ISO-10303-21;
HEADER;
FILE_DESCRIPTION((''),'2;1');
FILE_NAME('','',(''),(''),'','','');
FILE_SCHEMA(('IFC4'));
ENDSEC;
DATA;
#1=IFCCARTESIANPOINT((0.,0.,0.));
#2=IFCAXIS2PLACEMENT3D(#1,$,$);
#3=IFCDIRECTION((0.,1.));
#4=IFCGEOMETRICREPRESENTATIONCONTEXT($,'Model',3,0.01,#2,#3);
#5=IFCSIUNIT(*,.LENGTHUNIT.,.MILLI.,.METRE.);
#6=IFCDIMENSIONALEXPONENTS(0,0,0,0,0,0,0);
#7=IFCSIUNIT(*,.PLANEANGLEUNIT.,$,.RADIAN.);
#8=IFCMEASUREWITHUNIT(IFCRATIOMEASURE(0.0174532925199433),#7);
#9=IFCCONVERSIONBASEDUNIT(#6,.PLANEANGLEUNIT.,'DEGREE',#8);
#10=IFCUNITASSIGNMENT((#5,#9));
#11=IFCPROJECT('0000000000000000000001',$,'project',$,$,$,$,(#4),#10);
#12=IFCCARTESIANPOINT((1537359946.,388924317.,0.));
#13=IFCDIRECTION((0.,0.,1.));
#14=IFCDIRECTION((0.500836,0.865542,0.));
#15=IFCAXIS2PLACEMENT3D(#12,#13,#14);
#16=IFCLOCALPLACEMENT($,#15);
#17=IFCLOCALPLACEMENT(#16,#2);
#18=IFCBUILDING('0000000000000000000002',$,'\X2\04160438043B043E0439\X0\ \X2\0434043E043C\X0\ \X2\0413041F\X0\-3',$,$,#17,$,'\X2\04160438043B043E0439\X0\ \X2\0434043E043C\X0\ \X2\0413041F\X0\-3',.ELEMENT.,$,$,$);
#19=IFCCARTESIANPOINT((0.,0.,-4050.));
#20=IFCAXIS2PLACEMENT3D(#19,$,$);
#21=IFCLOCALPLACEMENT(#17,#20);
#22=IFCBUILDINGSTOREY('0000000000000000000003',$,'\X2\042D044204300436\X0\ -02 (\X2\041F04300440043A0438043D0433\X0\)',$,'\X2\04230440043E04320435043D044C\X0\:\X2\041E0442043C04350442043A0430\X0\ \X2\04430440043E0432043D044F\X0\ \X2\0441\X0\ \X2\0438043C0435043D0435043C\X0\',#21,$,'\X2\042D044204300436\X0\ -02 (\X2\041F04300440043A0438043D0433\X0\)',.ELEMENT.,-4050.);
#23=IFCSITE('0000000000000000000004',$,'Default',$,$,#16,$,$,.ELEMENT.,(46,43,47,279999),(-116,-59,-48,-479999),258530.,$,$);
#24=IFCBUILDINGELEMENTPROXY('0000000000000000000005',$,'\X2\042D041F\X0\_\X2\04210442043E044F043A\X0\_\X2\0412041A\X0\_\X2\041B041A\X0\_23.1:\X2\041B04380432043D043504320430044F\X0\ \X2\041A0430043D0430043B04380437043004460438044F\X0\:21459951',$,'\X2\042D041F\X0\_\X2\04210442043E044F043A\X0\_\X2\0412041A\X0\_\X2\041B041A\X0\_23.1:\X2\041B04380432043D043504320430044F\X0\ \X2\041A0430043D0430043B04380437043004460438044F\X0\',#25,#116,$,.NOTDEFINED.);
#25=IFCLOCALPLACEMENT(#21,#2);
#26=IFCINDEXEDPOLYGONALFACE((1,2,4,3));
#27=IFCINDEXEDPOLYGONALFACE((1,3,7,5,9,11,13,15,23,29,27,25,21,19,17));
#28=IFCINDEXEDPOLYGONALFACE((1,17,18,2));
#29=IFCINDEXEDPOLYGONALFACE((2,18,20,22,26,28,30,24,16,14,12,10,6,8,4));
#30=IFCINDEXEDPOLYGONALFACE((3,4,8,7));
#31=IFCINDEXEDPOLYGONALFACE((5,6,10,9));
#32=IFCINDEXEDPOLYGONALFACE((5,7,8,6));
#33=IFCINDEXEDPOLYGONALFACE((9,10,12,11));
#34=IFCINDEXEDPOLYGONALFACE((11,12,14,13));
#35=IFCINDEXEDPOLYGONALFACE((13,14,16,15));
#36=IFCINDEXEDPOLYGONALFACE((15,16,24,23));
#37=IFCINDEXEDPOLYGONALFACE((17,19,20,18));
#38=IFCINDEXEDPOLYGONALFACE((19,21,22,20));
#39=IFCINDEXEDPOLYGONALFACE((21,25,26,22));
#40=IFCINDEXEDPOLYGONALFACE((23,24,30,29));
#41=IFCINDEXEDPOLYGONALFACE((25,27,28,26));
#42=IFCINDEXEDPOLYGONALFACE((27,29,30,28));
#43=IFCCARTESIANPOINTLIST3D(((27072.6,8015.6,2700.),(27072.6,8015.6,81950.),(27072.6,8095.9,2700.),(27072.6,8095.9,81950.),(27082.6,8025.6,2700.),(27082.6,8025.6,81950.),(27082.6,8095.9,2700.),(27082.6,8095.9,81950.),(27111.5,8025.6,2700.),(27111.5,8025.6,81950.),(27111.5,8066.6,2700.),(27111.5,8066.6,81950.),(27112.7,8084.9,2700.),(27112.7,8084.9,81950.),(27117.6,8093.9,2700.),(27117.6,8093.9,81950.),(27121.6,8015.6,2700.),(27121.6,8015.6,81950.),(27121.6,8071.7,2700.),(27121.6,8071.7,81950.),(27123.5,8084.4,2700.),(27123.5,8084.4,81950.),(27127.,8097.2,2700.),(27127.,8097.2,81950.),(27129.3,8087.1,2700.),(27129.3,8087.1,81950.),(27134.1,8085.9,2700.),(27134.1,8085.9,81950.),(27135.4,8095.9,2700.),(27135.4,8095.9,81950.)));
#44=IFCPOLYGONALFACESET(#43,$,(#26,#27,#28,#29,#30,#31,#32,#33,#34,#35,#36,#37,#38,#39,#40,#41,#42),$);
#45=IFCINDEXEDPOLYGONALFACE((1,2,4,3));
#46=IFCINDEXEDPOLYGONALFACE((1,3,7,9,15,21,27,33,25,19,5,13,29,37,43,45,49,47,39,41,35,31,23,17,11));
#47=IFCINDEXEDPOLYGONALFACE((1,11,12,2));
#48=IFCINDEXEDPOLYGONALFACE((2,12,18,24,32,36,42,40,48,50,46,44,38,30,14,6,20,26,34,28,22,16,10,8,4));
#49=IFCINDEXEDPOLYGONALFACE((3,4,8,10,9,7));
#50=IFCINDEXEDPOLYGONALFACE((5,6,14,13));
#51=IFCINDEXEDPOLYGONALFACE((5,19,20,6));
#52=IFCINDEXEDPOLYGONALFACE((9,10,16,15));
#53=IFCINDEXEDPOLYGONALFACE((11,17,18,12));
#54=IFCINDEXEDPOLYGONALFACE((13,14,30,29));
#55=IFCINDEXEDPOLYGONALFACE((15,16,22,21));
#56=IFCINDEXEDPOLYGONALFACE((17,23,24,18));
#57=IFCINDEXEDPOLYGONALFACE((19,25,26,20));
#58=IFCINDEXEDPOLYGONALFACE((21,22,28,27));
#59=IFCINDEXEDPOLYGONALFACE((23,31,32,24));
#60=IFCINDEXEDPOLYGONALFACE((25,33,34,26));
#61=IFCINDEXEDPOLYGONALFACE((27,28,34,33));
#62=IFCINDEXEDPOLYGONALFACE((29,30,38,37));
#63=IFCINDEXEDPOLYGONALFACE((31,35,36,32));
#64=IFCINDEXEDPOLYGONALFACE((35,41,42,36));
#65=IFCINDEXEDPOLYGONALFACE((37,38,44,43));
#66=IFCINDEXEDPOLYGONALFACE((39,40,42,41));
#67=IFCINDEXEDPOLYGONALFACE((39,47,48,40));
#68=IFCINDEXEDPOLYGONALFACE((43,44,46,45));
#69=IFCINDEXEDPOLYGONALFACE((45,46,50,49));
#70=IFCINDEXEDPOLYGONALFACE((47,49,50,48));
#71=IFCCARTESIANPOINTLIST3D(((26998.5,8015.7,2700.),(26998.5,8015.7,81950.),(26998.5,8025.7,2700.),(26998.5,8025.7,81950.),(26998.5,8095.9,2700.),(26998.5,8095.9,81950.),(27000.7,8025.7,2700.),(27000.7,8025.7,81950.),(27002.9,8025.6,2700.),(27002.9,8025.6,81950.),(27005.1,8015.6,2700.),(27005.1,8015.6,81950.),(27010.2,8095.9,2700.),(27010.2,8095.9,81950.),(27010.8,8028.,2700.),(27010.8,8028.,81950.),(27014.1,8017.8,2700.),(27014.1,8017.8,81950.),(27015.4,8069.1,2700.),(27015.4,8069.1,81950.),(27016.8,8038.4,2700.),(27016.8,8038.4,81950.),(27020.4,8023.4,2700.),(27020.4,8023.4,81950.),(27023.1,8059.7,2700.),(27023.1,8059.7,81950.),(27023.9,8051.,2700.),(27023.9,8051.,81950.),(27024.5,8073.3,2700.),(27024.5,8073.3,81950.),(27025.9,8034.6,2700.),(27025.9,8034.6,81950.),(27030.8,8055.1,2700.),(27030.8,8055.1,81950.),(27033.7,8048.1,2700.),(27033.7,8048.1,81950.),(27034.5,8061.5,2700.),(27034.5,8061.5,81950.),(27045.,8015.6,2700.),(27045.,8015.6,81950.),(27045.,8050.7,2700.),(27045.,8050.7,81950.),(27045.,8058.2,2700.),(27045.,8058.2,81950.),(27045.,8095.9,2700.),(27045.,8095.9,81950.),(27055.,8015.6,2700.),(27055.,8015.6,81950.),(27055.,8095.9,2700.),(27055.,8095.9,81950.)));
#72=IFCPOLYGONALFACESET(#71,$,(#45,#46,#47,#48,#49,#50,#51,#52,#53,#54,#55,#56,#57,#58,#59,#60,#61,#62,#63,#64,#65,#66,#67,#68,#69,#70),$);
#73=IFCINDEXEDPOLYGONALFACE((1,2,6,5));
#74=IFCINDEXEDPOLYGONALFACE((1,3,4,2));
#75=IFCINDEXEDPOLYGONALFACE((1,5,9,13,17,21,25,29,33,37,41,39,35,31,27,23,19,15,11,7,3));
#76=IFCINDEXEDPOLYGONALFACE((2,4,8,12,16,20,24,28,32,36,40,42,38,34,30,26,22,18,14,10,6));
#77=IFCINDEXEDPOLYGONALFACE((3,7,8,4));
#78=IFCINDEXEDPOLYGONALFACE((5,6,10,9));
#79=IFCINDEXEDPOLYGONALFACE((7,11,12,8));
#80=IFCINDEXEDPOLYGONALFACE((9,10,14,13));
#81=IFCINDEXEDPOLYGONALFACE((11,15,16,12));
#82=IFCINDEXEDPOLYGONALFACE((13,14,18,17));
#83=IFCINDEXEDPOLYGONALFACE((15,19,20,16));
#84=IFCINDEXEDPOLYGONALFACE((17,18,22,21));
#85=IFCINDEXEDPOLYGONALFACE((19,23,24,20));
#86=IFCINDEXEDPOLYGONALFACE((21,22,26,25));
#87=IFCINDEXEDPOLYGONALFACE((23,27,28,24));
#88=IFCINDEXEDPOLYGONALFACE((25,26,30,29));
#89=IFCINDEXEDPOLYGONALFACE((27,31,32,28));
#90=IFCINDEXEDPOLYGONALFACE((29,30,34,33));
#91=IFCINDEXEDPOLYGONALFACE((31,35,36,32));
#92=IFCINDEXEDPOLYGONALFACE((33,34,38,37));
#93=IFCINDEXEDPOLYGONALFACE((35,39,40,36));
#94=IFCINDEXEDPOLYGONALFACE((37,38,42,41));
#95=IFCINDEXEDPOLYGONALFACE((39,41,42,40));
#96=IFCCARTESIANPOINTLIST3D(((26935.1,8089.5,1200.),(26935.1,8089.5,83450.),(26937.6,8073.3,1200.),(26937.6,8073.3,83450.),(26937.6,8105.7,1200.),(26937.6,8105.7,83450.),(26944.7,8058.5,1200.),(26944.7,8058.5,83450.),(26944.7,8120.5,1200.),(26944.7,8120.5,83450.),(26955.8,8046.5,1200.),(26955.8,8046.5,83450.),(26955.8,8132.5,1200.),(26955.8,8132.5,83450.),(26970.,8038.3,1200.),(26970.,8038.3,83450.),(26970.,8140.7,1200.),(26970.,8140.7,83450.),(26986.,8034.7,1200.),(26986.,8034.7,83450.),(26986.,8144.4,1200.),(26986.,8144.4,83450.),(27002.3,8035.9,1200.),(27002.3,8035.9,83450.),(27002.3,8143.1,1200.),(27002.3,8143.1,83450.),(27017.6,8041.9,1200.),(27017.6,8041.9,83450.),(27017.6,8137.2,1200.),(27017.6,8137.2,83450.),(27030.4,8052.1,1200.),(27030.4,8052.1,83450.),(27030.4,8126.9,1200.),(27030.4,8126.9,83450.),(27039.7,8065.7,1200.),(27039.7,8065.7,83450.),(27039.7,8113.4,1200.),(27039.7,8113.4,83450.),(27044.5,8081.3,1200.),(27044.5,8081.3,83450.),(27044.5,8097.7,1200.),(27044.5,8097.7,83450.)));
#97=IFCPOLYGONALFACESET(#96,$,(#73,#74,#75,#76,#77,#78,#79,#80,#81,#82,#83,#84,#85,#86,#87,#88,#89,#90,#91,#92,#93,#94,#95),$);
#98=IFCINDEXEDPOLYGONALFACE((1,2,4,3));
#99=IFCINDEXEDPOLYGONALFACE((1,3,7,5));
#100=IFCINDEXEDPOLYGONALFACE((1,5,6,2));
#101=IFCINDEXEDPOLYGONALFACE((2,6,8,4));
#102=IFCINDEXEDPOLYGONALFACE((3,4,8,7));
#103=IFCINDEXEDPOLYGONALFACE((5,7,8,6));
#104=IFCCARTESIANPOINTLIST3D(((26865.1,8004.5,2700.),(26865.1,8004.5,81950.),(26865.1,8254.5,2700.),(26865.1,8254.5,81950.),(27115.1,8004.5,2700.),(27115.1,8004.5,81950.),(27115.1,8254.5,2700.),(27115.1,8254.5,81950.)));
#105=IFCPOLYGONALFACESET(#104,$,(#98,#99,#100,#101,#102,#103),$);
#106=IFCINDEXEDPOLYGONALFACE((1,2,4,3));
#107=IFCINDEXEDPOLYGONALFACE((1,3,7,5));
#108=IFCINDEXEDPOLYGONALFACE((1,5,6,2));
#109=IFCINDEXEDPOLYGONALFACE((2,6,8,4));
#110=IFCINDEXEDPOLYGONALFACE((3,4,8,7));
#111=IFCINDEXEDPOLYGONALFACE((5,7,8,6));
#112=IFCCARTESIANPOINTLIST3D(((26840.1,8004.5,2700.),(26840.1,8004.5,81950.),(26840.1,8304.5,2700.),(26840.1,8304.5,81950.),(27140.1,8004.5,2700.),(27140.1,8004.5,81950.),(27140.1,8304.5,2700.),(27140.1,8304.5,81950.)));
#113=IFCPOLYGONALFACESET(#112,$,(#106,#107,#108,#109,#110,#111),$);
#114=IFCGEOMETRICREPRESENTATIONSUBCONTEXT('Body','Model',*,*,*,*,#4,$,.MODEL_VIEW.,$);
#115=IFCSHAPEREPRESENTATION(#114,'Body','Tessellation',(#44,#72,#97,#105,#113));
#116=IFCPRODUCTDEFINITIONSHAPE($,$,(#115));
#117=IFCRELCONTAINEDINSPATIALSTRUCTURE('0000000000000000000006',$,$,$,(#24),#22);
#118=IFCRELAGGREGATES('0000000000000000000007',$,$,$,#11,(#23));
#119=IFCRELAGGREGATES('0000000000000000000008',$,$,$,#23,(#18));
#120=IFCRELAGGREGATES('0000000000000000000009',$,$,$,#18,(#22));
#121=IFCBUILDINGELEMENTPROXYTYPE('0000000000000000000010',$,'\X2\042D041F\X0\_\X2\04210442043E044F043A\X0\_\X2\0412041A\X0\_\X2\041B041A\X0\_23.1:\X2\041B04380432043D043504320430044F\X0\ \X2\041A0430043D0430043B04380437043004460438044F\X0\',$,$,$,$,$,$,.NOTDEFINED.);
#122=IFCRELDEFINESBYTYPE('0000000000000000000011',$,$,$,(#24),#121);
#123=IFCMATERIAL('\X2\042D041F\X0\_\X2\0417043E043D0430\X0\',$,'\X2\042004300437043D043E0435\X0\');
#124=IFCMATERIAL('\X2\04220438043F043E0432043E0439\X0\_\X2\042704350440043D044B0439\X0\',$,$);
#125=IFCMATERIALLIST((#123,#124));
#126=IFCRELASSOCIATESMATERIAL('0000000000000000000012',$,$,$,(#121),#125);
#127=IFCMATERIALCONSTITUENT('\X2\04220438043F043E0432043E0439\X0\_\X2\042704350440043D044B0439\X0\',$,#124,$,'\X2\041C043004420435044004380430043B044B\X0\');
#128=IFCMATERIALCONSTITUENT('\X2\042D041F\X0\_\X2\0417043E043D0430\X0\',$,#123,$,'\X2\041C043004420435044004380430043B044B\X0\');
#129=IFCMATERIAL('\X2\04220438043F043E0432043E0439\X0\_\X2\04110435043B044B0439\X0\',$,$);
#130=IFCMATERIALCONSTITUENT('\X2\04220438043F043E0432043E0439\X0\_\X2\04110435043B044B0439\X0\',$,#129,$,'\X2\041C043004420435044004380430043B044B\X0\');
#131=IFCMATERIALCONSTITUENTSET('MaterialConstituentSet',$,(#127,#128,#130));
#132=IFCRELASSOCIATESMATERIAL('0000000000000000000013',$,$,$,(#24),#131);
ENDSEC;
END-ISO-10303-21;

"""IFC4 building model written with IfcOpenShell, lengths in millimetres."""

from ifc_helpers import new_model, entity, si_unit, converted_unit, direction, frame, frame_2d, origin, place, context, subcontext, project, spatial, polyline, rectangle, circle, outline, extrude, source, transform, mapped, material, material_list, constituent, constituent_set, type_object, type_shapes, element, save


model = new_model("IFC4")

# Units and contexts
model_context = context("Model", 3, precision=0.01, world=origin(), true_north=direction((0.0, 1.0)))
body_context = subcontext(model_context, "Body", "Model", "MODEL_VIEW")
ifc_project = project(units=[si_unit("LENGTHUNIT", "METRE", prefix="MILLI"), converted_unit("PLANEANGLEUNIT", "DEGREE", entity("IfcRatioMeasure", 0.0174532925199433), si_unit("PLANEANGLEUNIT", "RADIAN"), dimensions=[0, 0, 0, 0, 0, 0, 0])], contexts=[model_context])

# Site, building, storey
site_placement = place(None, frame((1537359946.0, 388924317.0, 0.0), z_axis=(0.0, 0.0, 1.0), x_axis=(0.500836, 0.865542, 0.0)))
site = spatial("IfcSite", under=ifc_project, at=site_placement, Name="Default", CompositionType="ELEMENT", RefLatitude=(46, 43, 47, 279999), RefLongitude=(-116, -59, -48, -479999), RefElevation=258530.0)
building_placement = place(site_placement, origin())
building = spatial("IfcBuilding", under=site, at=building_placement, Name="Жилой дом ГП-3", LongName="Жилой дом ГП-3", CompositionType="ELEMENT")
storey_placement = place(building_placement, frame((0.0, 0.0, -4050.0)))
storey = spatial("IfcBuildingStorey", under=building, at=storey_placement, Name="Этаж -02 (Паркинг)", ObjectType="Уровень:Отметка уровня с именем", LongName="Этаж -02 (Паркинг)", CompositionType="ELEMENT", Elevation=-4050.0)

# Building element proxy
ifc_material_1 = material(Name="Типовой_Черный")
ifc_material_2 = material(Name="ЭП_Зона", Category="Разное")
ifc_constituent_1 = constituent(ifc_material_1, Name="Типовой_Черный", Category="Материалы")
ifc_constituent_2 = constituent(ifc_material_2, Name="ЭП_Зона", Category="Материалы")
ifc_material_3 = material(Name="Типовой_Белый")
ifc_constituent_3 = constituent(ifc_material_3, Name="Типовой_Белый", Category="Материалы")
ifc_constituent_set_1 = constituent_set(constituents=[ifc_constituent_1, ifc_constituent_2, ifc_constituent_3], Name="MaterialConstituentSet")
ifc_material_list_1 = material_list([ifc_material_2, ifc_material_1])
building_element_proxy_type_1 = type_object("IfcBuildingElementProxyType", Name="ЭП_Стояк_ВК_ЛК_23.1:Ливневая Канализация", PredefinedType="NOTDEFINED", material=ifc_material_list_1)
shared_shape_1 = source(origin(), body_context, "Body", "SweptSolid", [
    extrude(outline(polyline([(-53.9, 11.1), (-53.9, -37.8), (26.5, -37.8), (26.5, -27.8), (-43.9, -27.8), (-43.9, 1.1), (-2.9, 1.1), (15.4, 2.3), (24.5, 7.2), (27.7, 16.6), (26.5, 25.0), (16.4, 23.7), (17.7, 18.9), (15.0, 13.1), (2.3, 11.1), (-53.9, 11.1)])), frame((29.7, -64.9, -1350.0), z_axis=(0.0, 0.0, -1.0), x_axis=(0.0, -1.0, 0.0)), (0.0, 0.0, -1.0), 79250.0),
    extrude(outline(polyline([(-32.1, -31.9), (48.3, -31.9), (48.3, -21.8), (10.6, -21.8), (13.8, -11.4), (25.6, -1.3), (48.3, 13.0), (48.3, 24.6), (21.4, 7.7), (12.0, 0.1), (7.4, -7.7), (3.3, -0.7), (-9.3, 6.4), (-19.7, 12.3), (-22.1, 20.2), (-22.0, 22.4), (-22.0, 24.6), (-32.0, 24.6), (-32.1, 18.0), (-29.9, 9.0), (-24.3, 2.8), (-13.1, -2.8), (0.4, -10.6), (3.0, -21.8), (-32.1, -21.8), (-32.1, -31.9)])), frame((117.0, -43.1, -1350.0), z_axis=(0.0, 0.0, 1.0), x_axis=(0.0, -1.0, 0.0)), (0.0, 0.0, 1.0), 79250.0),
    extrude(circle(Radius=55.0, at=frame_2d((0.0, 0.0), x_axis=(1.0, 0.0))), frame((150.0, -85.0, -2850.0)), (0.0, 0.0, 1.0), 82250.0),
    extrude(rectangle(XDim=250.0, YDim=250.0, at=frame_2d((0.0, 0.0), x_axis=(1.0, 0.0))), frame((150.0, -125.0, -1350.0)), (0.0, 0.0, 1.0), 79250.0),
    extrude(rectangle(XDim=300.0, YDim=300.0, at=frame_2d((0.0, 0.0), x_axis=(1.0, 0.0))), frame((150.0, -150.0, -1350.0)), (0.0, 0.0, 1.0), 79250.0),
])
type_shapes(building_element_proxy_type_1, [shared_shape_1])
proxy_1_placement = place(storey_placement, frame((27140.1, 8004.5, 4050.0), z_axis=(0.0, 0.0, 1.0), x_axis=(-1.0, 0.0, 0.0)))
element("IfcBuildingElementProxy", 1, at=proxy_1_placement, inside=storey, type_object=building_element_proxy_type_1, material=ifc_constituent_set_1, Name="ЭП_Стояк_ВК_ЛК_23.1:Ливневая Канализация:21459951", ObjectType="ЭП_Стояк_ВК_ЛК_23.1:Ливневая Канализация", PredefinedType="NOTDEFINED", context=body_context, shape_type="MappedRepresentation", body=[
    mapped(shared_shape_1, transform((0.0, 0.0, 0.0), scale=1.0)),
])

save(model, "model.ifc")
